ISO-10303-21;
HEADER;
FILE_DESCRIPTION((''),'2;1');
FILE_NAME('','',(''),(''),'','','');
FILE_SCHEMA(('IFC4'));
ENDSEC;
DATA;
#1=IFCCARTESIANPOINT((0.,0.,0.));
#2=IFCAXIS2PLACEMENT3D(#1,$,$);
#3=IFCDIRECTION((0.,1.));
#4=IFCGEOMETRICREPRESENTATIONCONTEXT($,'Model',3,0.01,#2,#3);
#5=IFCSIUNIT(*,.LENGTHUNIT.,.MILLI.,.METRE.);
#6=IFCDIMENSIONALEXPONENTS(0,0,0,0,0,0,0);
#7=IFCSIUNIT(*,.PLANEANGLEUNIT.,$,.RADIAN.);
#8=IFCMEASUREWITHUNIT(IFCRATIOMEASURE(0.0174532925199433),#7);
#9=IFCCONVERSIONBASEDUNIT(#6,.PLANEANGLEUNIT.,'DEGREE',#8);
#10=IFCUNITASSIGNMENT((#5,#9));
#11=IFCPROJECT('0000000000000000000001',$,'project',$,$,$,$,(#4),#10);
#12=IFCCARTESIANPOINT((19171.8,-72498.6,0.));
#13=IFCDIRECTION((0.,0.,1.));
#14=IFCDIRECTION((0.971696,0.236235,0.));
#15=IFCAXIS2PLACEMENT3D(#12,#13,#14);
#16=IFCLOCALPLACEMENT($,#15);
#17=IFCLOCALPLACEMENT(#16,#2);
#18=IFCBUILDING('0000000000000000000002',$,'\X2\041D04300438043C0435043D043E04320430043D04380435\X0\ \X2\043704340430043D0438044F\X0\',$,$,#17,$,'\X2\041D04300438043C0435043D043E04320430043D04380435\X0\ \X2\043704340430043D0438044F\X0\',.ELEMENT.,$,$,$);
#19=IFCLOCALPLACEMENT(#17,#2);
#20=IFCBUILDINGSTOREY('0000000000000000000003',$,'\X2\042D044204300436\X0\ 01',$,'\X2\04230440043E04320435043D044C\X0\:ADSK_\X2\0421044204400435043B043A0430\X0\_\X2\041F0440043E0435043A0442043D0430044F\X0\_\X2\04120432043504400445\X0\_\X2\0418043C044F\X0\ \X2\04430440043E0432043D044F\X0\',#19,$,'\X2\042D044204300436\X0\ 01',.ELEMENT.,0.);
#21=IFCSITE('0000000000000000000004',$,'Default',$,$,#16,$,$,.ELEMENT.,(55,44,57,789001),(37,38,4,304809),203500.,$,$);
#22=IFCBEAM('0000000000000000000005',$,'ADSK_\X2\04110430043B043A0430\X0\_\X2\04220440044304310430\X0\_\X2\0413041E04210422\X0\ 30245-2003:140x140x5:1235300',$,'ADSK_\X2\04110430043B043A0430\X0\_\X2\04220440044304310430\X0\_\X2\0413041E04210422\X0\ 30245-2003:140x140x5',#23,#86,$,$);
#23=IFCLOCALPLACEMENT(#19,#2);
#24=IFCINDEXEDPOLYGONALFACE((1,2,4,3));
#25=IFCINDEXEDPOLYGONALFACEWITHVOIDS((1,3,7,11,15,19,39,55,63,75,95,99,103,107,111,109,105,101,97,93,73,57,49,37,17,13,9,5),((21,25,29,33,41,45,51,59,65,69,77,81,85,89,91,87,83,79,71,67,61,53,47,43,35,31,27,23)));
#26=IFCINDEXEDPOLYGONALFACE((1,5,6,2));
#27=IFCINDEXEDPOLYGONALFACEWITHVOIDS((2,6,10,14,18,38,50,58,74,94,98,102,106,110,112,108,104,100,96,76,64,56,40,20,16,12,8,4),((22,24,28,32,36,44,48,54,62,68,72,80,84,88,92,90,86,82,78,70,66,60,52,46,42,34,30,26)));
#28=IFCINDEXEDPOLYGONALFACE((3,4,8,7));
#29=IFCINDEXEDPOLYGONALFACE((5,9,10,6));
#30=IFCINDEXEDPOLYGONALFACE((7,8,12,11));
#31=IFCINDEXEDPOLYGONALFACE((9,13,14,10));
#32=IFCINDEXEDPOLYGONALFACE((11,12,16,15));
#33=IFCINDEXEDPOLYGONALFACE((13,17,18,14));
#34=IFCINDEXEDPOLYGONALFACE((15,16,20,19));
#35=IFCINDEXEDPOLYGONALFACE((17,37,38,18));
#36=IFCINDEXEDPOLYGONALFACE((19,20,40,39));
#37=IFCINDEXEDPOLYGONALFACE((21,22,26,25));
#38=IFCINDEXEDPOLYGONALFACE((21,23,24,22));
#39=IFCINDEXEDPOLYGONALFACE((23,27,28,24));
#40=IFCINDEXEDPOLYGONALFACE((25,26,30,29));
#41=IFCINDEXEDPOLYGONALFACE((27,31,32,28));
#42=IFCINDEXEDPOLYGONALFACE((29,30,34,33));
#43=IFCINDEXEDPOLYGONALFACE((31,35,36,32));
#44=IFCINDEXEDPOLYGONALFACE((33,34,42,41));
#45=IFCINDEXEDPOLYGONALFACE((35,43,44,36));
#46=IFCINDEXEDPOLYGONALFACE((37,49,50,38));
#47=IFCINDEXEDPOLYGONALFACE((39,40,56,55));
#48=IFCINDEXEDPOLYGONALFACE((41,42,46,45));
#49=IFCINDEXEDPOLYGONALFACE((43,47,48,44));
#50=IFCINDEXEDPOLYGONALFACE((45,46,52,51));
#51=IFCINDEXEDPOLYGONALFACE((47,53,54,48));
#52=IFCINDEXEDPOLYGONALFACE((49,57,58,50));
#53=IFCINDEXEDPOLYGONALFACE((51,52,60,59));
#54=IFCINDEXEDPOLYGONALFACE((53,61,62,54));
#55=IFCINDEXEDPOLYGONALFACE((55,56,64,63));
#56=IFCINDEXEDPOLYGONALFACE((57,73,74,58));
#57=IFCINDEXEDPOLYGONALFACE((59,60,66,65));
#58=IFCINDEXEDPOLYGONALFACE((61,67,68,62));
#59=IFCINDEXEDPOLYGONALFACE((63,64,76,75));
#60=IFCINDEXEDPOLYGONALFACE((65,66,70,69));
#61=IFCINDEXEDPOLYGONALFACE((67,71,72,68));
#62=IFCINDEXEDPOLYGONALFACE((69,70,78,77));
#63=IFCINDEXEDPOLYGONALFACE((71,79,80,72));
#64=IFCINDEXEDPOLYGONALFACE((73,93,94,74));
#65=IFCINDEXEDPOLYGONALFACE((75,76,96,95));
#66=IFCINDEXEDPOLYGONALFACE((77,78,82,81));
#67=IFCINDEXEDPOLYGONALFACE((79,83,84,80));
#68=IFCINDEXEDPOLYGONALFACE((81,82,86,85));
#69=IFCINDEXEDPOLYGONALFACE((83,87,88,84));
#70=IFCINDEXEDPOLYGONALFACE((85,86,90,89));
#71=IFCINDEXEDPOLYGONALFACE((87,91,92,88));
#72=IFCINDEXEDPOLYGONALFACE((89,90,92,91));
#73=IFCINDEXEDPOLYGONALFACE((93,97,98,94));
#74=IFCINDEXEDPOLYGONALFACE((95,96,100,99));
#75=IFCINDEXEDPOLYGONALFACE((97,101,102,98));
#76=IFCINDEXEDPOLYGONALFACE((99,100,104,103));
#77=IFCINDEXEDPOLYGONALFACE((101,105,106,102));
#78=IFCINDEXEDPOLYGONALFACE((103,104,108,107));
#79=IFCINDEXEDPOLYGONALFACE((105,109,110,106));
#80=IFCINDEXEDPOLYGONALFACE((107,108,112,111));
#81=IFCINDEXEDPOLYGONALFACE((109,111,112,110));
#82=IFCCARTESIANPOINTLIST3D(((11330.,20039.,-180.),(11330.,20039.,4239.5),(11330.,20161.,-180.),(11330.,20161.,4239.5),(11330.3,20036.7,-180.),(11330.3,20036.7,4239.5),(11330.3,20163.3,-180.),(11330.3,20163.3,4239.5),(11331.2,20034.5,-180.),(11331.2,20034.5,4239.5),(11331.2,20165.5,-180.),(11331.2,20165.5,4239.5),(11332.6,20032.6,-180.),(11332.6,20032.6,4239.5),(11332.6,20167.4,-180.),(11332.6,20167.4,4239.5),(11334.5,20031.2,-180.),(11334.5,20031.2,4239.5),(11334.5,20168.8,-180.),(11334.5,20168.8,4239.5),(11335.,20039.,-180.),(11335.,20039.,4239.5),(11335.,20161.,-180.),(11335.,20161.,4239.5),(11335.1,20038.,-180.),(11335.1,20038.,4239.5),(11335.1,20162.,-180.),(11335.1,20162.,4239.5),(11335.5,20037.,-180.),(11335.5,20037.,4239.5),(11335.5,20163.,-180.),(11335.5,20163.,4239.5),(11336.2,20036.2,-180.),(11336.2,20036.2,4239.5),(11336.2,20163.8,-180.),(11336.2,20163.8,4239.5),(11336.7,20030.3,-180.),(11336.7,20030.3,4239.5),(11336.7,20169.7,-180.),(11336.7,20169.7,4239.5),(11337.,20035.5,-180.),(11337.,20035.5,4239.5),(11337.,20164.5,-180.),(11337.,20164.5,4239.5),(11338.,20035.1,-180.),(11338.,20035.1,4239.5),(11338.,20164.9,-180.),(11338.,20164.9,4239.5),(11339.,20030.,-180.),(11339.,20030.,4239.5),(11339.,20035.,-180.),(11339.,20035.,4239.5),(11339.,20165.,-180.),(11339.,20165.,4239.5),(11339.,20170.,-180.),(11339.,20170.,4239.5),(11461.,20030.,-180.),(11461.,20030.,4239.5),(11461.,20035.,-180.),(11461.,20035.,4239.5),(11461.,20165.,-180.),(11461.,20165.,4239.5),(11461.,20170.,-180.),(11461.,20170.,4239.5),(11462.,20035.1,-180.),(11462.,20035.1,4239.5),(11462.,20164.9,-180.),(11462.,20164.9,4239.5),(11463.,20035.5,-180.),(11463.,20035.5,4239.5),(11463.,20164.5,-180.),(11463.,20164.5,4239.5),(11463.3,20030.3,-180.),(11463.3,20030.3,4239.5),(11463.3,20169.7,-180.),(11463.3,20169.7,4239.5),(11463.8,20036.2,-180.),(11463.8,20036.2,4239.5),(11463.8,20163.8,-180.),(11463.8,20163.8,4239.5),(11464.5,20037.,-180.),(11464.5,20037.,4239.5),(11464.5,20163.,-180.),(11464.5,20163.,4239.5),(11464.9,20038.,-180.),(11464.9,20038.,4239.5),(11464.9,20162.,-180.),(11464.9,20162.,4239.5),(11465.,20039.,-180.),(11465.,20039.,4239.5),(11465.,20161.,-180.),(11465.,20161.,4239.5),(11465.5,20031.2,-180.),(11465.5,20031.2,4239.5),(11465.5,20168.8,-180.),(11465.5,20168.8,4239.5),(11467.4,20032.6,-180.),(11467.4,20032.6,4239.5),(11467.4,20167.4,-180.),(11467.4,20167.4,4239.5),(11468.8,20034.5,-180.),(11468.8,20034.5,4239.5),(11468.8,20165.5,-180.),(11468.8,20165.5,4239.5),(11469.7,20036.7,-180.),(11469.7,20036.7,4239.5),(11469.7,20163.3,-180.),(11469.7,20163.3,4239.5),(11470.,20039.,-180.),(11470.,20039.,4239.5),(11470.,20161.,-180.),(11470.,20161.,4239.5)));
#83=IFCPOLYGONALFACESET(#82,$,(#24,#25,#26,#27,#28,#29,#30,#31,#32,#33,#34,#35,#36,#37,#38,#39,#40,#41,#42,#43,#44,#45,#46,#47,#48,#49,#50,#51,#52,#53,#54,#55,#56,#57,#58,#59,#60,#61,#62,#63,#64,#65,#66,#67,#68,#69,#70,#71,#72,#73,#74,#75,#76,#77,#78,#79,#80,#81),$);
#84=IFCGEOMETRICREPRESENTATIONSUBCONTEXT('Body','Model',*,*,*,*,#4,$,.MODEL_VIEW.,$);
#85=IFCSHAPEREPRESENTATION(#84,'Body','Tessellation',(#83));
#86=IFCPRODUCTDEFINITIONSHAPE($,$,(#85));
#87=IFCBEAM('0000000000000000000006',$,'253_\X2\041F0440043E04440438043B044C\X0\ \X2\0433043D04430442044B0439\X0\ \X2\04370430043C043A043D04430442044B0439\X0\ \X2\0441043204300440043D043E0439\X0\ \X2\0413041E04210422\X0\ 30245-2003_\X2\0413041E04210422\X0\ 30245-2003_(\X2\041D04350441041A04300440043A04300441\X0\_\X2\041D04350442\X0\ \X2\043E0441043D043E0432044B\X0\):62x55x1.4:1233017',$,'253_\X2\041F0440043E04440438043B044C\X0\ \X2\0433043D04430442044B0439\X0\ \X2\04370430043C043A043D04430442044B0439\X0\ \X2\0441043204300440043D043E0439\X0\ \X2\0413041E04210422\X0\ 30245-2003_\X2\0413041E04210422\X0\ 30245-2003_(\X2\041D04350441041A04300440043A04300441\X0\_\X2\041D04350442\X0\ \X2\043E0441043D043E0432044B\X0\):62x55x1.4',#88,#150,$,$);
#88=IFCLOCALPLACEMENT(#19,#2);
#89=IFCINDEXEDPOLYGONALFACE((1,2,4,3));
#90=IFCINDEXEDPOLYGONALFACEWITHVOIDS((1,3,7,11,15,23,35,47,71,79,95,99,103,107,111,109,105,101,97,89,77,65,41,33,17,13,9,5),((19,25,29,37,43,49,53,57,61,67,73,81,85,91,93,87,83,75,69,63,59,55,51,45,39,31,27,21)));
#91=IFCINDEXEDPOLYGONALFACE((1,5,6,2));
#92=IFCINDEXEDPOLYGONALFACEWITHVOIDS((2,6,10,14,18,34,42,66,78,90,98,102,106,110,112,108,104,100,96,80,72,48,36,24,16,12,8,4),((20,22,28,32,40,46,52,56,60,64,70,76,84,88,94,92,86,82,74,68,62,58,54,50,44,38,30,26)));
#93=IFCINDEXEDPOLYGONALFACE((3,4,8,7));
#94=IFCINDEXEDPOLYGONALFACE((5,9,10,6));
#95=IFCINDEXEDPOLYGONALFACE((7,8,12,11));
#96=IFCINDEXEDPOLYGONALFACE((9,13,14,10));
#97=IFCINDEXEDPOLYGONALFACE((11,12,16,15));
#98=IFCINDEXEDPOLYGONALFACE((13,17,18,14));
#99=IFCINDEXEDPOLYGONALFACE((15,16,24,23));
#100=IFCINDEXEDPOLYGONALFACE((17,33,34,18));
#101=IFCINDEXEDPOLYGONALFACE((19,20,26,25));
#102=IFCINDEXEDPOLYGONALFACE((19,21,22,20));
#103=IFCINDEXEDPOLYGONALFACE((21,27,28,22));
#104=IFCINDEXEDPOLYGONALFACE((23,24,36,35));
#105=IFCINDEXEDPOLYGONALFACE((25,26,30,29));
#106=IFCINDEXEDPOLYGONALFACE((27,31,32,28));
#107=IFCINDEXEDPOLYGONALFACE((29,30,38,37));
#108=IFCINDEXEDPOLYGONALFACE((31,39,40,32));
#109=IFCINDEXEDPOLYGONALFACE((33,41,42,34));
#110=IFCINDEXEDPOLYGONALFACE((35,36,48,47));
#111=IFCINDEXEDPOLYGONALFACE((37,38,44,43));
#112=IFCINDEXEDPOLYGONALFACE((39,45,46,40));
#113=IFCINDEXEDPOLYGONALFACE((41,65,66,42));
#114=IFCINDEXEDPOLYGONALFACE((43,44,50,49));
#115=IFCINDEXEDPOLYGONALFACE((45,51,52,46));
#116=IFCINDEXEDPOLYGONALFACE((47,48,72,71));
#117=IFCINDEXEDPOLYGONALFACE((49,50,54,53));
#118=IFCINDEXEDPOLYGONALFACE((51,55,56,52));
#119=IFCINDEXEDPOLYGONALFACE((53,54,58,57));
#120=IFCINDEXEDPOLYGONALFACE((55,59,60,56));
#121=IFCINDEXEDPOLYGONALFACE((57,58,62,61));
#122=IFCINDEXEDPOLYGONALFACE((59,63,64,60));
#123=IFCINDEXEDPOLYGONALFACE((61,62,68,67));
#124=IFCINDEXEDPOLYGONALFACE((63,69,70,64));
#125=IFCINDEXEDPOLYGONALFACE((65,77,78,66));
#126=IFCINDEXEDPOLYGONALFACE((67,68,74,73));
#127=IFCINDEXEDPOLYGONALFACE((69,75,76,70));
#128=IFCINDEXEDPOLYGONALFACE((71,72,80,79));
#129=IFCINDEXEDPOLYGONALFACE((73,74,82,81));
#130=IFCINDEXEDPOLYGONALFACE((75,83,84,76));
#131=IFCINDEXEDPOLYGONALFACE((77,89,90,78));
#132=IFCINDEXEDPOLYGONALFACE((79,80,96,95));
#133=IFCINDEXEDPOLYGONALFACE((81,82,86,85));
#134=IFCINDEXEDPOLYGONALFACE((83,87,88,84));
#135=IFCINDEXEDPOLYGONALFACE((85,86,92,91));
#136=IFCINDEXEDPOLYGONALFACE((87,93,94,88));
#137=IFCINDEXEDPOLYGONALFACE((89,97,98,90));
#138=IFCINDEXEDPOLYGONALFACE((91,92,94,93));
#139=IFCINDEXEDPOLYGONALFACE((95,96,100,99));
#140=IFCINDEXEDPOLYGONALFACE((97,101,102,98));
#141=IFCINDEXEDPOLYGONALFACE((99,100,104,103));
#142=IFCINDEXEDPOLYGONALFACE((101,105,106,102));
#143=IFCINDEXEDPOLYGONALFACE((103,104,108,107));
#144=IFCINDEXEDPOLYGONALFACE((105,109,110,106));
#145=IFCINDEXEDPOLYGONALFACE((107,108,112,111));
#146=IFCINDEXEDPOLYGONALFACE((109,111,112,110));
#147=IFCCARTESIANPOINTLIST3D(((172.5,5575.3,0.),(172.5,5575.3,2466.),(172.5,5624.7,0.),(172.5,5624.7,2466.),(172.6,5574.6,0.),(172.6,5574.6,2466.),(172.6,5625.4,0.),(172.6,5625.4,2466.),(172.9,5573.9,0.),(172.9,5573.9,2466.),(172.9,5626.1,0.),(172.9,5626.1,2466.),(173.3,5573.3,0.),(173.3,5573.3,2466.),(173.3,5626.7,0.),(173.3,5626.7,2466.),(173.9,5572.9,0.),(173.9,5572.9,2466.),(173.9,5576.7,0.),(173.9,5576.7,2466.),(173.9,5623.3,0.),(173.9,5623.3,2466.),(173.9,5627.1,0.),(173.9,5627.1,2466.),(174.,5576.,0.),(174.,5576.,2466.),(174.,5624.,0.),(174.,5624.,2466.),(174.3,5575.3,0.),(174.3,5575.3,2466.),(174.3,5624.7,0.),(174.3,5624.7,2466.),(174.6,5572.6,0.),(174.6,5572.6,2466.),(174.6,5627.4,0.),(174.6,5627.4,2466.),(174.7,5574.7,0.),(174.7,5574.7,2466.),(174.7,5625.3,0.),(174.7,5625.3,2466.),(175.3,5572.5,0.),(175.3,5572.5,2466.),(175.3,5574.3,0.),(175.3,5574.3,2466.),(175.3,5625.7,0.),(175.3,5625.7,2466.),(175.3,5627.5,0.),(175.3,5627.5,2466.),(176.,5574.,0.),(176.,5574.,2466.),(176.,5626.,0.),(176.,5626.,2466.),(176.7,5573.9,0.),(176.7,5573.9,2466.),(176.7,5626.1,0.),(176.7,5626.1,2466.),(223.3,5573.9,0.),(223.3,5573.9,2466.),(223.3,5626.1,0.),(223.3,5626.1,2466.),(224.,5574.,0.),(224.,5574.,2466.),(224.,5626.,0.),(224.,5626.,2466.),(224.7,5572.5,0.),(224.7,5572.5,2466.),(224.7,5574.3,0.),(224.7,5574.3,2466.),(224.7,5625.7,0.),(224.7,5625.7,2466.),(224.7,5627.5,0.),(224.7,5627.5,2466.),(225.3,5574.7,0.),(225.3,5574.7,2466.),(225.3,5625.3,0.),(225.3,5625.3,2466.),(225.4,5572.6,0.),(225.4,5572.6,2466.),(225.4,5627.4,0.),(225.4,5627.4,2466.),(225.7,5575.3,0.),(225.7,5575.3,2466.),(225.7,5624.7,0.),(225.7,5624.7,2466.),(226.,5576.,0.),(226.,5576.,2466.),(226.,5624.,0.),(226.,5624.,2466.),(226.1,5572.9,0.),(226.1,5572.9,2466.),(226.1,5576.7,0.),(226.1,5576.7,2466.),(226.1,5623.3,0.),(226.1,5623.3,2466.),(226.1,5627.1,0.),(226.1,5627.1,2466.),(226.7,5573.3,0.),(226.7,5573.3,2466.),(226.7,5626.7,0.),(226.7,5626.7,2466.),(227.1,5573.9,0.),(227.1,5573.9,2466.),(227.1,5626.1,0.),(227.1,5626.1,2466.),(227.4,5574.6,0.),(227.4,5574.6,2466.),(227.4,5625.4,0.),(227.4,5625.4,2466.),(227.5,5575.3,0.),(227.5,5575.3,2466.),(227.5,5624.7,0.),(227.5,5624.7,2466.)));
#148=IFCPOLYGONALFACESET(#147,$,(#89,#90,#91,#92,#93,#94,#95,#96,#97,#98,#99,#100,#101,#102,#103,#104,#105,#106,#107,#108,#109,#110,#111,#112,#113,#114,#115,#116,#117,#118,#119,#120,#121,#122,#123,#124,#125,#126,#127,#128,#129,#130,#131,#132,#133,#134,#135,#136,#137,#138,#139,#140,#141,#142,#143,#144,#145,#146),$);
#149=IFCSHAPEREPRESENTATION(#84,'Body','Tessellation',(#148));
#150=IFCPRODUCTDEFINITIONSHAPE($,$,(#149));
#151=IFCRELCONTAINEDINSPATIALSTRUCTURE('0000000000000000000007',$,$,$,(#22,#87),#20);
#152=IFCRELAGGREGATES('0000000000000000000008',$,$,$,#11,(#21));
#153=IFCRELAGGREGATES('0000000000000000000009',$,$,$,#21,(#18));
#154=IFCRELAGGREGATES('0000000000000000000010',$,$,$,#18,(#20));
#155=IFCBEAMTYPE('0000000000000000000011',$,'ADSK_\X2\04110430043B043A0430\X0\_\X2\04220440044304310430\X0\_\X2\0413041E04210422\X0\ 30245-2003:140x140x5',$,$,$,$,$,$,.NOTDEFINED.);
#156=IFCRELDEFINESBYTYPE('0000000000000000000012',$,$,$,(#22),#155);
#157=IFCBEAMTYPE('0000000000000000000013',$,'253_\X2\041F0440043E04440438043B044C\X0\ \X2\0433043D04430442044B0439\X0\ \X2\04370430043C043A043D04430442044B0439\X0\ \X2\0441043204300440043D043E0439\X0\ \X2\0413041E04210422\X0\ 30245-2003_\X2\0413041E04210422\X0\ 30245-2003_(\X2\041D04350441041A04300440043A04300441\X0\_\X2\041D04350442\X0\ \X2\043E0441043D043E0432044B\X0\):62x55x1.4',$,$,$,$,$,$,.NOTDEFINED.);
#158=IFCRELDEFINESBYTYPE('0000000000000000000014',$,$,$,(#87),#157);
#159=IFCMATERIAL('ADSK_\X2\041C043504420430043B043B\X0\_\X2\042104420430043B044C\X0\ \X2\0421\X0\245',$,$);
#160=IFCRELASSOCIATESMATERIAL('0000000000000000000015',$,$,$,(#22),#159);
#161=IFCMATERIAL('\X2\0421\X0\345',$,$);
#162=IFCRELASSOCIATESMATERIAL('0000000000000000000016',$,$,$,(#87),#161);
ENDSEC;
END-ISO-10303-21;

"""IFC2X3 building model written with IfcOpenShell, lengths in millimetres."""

from ifc_helpers import new_model, entity, si_unit, converted_unit, direction, frame, frame_2d, origin, place, context, subcontext, project, spatial, polyline, circle_curve, parameter, trimmed, segment, composite_curve, outline, extrude, material, type_object, element, save


model = new_model("IFC2X3")

# Units and contexts
model_context = context("Model", 3, precision=0.01, world=origin(), true_north=direction((0.0, 1.0)))
body_context = subcontext(model_context, "Body", "Model", "MODEL_VIEW")
ifc_project = project(units=[si_unit("LENGTHUNIT", "METRE", prefix="MILLI"), converted_unit("PLANEANGLEUNIT", "DEGREE", entity("IfcRatioMeasure", 0.0174532925199433), si_unit("PLANEANGLEUNIT", "RADIAN"), dimensions=[0, 0, 0, 0, 0, 0, 0])], contexts=[model_context])

# Site, building, storey
site_placement = place(None, frame((19171.8, -72498.6, 0.0), z_axis=(0.0, 0.0, 1.0), x_axis=(0.971696, 0.236235, 0.0)))
site = spatial("IfcSite", under=ifc_project, at=site_placement, Name="Default", CompositionType="ELEMENT", RefLatitude=(55, 44, 57, 789001), RefLongitude=(37, 38, 4, 304809), RefElevation=203500.0)
building_placement = place(site_placement, origin())
building = spatial("IfcBuilding", under=site, at=building_placement, Name="Наименование здания", LongName="Наименование здания", CompositionType="ELEMENT")
storey_placement = place(building_placement, origin())
storey = spatial("IfcBuildingStorey", under=building, at=storey_placement, Name="Этаж 01", ObjectType="Уровень:ADSK_Стрелка_Проектная_Вверх_Имя уровня", LongName="Этаж 01", CompositionType="ELEMENT", Elevation=0.0)

# Beams
ifc_material_1 = material(Name="ADSK_Металл_Сталь С245")
beam_type_1 = type_object("IfcBeamType", Name="ADSK_Балка_Труба_ГОСТ 30245-2003:140x140x5", PredefinedType="NOTDEFINED")
beam_1_placement = place(storey_placement, frame((11328.4, 20028.4, -180.0), z_axis=(1.0, 0.0, 0.0), x_axis=(0.0, 0.0, -1.0)))
element("IfcBeam", 1, at=beam_1_placement, inside=storey, type_object=beam_type_1, material=ifc_material_1, Name="ADSK_Балка_Труба_ГОСТ 30245-2003:140x140x5:1235300", ObjectType="ADSK_Балка_Труба_ГОСТ 30245-2003:140x140x5", context=body_context, shape_type="SweptSolid", body=[
    extrude(outline(composite_curve([segment(trimmed(circle_curve(frame_2d((61.0, -61.0), x_axis=(1.0, 0.0)), 9.0), [parameter(270.0)], [parameter(0.0)], True, "PARAMETER"), True, "CONTINUOUS"), segment(polyline([(70.0, -61.0), (70.0, 61.0)]), True, "CONTINUOUS"), segment(trimmed(circle_curve(frame_2d((61.0, 61.0), x_axis=(1.0, 0.0)), 9.0), [parameter(0.0)], [parameter(90.0)], True, "PARAMETER"), True, "CONTINUOUS"), segment(polyline([(61.0, 70.0), (-61.0, 70.0)]), True, "CONTINUOUS"), segment(trimmed(circle_curve(frame_2d((-61.0, 61.0), x_axis=(1.0, 0.0)), 9.0), [parameter(90.0)], [parameter(180.0)], True, "PARAMETER"), True, "CONTINUOUS"), segment(polyline([(-70.0, 61.0), (-70.0, -61.0)]), True, "CONTINUOUS"), segment(trimmed(circle_curve(frame_2d((-61.0, -61.0), x_axis=(1.0, 0.0)), 9.0), [parameter(180.0)], [parameter(270.0)], True, "PARAMETER"), True, "CONTINUOUS"), segment(polyline([(-61.0, -70.0), (61.0, -70.0)]), True, "CONTINUOUS")], self_intersect=False), holes=[composite_curve([segment(polyline([(61.0, -65.0), (-61.0, -65.0)]), True, "CONTINUOUS"), segment(trimmed(circle_curve(frame_2d((-61.0, -61.0), x_axis=(1.0, 0.0)), 4.0), [parameter(180.0)], [parameter(270.0)], True, "PARAMETER"), False, "CONTINUOUS"), segment(polyline([(-65.0, -61.0), (-65.0, 61.0)]), True, "CONTINUOUS"), segment(trimmed(circle_curve(frame_2d((-61.0, 61.0), x_axis=(1.0, 0.0)), 4.0), [parameter(90.0)], [parameter(180.0)], True, "PARAMETER"), False, "CONTINUOUS"), segment(polyline([(-61.0, 65.0), (61.0, 65.0)]), True, "CONTINUOUS"), segment(trimmed(circle_curve(frame_2d((61.0, 61.0), x_axis=(1.0, 0.0)), 4.0), [parameter(0.0)], [parameter(90.0)], True, "PARAMETER"), False, "CONTINUOUS"), segment(polyline([(65.0, 61.0), (65.0, -61.0)]), True, "CONTINUOUS"), segment(trimmed(circle_curve(frame_2d((61.0, -61.0), x_axis=(1.0, 0.0)), 4.0), [parameter(270.0)], [parameter(0.0)], True, "PARAMETER"), False, "CONTINUOUS")], self_intersect=False)]), frame((-4419.5, 71.6, 71.6), z_axis=(1.0, 0.0, 0.0), x_axis=(0.0, 0.0, 1.0)), (0.0, 0.0, 1.0), 4419.5),
])
ifc_material_2 = material(Name="С345")
beam_type_2 = type_object("IfcBeamType", Name="253_Профиль гнутый замкнутый сварной ГОСТ 30245-2003_ГОСТ 30245-2003_(НесКаркас_Нет основы):62x55x1.4", PredefinedType="NOTDEFINED")
beam_2_placement = place(storey_placement, frame((170.9, 5570.9, 0.0), z_axis=(1.0, 0.0, 0.0), x_axis=(0.0, 0.0, -1.0)))
element("IfcBeam", 2, at=beam_2_placement, inside=storey, type_object=beam_type_2, material=ifc_material_2, Name="253_Профиль гнутый замкнутый сварной ГОСТ 30245-2003_ГОСТ 30245-2003_(НесКаркас_Нет основы):62x55x1.4:1233017", ObjectType="253_Профиль гнутый замкнутый сварной ГОСТ 30245-2003_ГОСТ 30245-2003_(НесКаркас_Нет основы):62x55x1.4", context=body_context, shape_type="SweptSolid", body=[
    extrude(outline(composite_curve([segment(trimmed(circle_curve(frame_2d((24.7, -24.7), x_axis=(1.0, 0.0)), 2.8), [parameter(270.0)], [parameter(0.0)], True, "PARAMETER"), True, "CONTINUOUS"), segment(polyline([(27.5, -24.7), (27.5, 24.7)]), True, "CONTINUOUS"), segment(trimmed(circle_curve(frame_2d((24.7, 24.7), x_axis=(1.0, 0.0)), 2.8), [parameter(0.0)], [parameter(90.0)], True, "PARAMETER"), True, "CONTINUOUS"), segment(polyline([(24.7, 27.5), (-24.7, 27.5)]), True, "CONTINUOUS"), segment(trimmed(circle_curve(frame_2d((-24.7, 24.7), x_axis=(1.0, 0.0)), 2.8), [parameter(90.0)], [parameter(180.0)], True, "PARAMETER"), True, "CONTINUOUS"), segment(polyline([(-27.5, 24.7), (-27.5, -24.7)]), True, "CONTINUOUS"), segment(trimmed(circle_curve(frame_2d((-24.7, -24.7), x_axis=(1.0, 0.0)), 2.8), [parameter(180.0)], [parameter(270.0)], True, "PARAMETER"), True, "CONTINUOUS"), segment(polyline([(-24.7, -27.5), (24.7, -27.5)]), True, "CONTINUOUS")], self_intersect=False), holes=[composite_curve([segment(polyline([(23.3, -26.1), (-23.3, -26.1)]), True, "CONTINUOUS"), segment(trimmed(circle_curve(frame_2d((-23.3, -23.3), x_axis=(1.0, 0.0)), 2.8), [parameter(180.0)], [parameter(270.0)], True, "PARAMETER"), False, "CONTINUOUS"), segment(polyline([(-26.1, -23.3), (-26.1, 23.3)]), True, "CONTINUOUS"), segment(trimmed(circle_curve(frame_2d((-23.3, 23.3), x_axis=(1.0, 0.0)), 2.8), [parameter(90.0)], [parameter(180.0)], True, "PARAMETER"), False, "CONTINUOUS"), segment(polyline([(-23.3, 26.1), (23.3, 26.1)]), True, "CONTINUOUS"), segment(trimmed(circle_curve(frame_2d((23.3, 23.3), x_axis=(1.0, 0.0)), 2.8), [parameter(0.0)], [parameter(90.0)], True, "PARAMETER"), False, "CONTINUOUS"), segment(polyline([(26.1, 23.3), (26.1, -23.3)]), True, "CONTINUOUS"), segment(trimmed(circle_curve(frame_2d((23.3, -23.3), x_axis=(1.0, 0.0)), 2.8), [parameter(270.0)], [parameter(0.0)], True, "PARAMETER"), False, "CONTINUOUS")], self_intersect=False)]), frame((-2466.0, 29.1, 29.1), z_axis=(1.0, 0.0, 0.0), x_axis=(0.0, 1.0, 0.0)), (0.0, 0.0, 1.0), 2466.0),
])

save(model, "model.ifc")
